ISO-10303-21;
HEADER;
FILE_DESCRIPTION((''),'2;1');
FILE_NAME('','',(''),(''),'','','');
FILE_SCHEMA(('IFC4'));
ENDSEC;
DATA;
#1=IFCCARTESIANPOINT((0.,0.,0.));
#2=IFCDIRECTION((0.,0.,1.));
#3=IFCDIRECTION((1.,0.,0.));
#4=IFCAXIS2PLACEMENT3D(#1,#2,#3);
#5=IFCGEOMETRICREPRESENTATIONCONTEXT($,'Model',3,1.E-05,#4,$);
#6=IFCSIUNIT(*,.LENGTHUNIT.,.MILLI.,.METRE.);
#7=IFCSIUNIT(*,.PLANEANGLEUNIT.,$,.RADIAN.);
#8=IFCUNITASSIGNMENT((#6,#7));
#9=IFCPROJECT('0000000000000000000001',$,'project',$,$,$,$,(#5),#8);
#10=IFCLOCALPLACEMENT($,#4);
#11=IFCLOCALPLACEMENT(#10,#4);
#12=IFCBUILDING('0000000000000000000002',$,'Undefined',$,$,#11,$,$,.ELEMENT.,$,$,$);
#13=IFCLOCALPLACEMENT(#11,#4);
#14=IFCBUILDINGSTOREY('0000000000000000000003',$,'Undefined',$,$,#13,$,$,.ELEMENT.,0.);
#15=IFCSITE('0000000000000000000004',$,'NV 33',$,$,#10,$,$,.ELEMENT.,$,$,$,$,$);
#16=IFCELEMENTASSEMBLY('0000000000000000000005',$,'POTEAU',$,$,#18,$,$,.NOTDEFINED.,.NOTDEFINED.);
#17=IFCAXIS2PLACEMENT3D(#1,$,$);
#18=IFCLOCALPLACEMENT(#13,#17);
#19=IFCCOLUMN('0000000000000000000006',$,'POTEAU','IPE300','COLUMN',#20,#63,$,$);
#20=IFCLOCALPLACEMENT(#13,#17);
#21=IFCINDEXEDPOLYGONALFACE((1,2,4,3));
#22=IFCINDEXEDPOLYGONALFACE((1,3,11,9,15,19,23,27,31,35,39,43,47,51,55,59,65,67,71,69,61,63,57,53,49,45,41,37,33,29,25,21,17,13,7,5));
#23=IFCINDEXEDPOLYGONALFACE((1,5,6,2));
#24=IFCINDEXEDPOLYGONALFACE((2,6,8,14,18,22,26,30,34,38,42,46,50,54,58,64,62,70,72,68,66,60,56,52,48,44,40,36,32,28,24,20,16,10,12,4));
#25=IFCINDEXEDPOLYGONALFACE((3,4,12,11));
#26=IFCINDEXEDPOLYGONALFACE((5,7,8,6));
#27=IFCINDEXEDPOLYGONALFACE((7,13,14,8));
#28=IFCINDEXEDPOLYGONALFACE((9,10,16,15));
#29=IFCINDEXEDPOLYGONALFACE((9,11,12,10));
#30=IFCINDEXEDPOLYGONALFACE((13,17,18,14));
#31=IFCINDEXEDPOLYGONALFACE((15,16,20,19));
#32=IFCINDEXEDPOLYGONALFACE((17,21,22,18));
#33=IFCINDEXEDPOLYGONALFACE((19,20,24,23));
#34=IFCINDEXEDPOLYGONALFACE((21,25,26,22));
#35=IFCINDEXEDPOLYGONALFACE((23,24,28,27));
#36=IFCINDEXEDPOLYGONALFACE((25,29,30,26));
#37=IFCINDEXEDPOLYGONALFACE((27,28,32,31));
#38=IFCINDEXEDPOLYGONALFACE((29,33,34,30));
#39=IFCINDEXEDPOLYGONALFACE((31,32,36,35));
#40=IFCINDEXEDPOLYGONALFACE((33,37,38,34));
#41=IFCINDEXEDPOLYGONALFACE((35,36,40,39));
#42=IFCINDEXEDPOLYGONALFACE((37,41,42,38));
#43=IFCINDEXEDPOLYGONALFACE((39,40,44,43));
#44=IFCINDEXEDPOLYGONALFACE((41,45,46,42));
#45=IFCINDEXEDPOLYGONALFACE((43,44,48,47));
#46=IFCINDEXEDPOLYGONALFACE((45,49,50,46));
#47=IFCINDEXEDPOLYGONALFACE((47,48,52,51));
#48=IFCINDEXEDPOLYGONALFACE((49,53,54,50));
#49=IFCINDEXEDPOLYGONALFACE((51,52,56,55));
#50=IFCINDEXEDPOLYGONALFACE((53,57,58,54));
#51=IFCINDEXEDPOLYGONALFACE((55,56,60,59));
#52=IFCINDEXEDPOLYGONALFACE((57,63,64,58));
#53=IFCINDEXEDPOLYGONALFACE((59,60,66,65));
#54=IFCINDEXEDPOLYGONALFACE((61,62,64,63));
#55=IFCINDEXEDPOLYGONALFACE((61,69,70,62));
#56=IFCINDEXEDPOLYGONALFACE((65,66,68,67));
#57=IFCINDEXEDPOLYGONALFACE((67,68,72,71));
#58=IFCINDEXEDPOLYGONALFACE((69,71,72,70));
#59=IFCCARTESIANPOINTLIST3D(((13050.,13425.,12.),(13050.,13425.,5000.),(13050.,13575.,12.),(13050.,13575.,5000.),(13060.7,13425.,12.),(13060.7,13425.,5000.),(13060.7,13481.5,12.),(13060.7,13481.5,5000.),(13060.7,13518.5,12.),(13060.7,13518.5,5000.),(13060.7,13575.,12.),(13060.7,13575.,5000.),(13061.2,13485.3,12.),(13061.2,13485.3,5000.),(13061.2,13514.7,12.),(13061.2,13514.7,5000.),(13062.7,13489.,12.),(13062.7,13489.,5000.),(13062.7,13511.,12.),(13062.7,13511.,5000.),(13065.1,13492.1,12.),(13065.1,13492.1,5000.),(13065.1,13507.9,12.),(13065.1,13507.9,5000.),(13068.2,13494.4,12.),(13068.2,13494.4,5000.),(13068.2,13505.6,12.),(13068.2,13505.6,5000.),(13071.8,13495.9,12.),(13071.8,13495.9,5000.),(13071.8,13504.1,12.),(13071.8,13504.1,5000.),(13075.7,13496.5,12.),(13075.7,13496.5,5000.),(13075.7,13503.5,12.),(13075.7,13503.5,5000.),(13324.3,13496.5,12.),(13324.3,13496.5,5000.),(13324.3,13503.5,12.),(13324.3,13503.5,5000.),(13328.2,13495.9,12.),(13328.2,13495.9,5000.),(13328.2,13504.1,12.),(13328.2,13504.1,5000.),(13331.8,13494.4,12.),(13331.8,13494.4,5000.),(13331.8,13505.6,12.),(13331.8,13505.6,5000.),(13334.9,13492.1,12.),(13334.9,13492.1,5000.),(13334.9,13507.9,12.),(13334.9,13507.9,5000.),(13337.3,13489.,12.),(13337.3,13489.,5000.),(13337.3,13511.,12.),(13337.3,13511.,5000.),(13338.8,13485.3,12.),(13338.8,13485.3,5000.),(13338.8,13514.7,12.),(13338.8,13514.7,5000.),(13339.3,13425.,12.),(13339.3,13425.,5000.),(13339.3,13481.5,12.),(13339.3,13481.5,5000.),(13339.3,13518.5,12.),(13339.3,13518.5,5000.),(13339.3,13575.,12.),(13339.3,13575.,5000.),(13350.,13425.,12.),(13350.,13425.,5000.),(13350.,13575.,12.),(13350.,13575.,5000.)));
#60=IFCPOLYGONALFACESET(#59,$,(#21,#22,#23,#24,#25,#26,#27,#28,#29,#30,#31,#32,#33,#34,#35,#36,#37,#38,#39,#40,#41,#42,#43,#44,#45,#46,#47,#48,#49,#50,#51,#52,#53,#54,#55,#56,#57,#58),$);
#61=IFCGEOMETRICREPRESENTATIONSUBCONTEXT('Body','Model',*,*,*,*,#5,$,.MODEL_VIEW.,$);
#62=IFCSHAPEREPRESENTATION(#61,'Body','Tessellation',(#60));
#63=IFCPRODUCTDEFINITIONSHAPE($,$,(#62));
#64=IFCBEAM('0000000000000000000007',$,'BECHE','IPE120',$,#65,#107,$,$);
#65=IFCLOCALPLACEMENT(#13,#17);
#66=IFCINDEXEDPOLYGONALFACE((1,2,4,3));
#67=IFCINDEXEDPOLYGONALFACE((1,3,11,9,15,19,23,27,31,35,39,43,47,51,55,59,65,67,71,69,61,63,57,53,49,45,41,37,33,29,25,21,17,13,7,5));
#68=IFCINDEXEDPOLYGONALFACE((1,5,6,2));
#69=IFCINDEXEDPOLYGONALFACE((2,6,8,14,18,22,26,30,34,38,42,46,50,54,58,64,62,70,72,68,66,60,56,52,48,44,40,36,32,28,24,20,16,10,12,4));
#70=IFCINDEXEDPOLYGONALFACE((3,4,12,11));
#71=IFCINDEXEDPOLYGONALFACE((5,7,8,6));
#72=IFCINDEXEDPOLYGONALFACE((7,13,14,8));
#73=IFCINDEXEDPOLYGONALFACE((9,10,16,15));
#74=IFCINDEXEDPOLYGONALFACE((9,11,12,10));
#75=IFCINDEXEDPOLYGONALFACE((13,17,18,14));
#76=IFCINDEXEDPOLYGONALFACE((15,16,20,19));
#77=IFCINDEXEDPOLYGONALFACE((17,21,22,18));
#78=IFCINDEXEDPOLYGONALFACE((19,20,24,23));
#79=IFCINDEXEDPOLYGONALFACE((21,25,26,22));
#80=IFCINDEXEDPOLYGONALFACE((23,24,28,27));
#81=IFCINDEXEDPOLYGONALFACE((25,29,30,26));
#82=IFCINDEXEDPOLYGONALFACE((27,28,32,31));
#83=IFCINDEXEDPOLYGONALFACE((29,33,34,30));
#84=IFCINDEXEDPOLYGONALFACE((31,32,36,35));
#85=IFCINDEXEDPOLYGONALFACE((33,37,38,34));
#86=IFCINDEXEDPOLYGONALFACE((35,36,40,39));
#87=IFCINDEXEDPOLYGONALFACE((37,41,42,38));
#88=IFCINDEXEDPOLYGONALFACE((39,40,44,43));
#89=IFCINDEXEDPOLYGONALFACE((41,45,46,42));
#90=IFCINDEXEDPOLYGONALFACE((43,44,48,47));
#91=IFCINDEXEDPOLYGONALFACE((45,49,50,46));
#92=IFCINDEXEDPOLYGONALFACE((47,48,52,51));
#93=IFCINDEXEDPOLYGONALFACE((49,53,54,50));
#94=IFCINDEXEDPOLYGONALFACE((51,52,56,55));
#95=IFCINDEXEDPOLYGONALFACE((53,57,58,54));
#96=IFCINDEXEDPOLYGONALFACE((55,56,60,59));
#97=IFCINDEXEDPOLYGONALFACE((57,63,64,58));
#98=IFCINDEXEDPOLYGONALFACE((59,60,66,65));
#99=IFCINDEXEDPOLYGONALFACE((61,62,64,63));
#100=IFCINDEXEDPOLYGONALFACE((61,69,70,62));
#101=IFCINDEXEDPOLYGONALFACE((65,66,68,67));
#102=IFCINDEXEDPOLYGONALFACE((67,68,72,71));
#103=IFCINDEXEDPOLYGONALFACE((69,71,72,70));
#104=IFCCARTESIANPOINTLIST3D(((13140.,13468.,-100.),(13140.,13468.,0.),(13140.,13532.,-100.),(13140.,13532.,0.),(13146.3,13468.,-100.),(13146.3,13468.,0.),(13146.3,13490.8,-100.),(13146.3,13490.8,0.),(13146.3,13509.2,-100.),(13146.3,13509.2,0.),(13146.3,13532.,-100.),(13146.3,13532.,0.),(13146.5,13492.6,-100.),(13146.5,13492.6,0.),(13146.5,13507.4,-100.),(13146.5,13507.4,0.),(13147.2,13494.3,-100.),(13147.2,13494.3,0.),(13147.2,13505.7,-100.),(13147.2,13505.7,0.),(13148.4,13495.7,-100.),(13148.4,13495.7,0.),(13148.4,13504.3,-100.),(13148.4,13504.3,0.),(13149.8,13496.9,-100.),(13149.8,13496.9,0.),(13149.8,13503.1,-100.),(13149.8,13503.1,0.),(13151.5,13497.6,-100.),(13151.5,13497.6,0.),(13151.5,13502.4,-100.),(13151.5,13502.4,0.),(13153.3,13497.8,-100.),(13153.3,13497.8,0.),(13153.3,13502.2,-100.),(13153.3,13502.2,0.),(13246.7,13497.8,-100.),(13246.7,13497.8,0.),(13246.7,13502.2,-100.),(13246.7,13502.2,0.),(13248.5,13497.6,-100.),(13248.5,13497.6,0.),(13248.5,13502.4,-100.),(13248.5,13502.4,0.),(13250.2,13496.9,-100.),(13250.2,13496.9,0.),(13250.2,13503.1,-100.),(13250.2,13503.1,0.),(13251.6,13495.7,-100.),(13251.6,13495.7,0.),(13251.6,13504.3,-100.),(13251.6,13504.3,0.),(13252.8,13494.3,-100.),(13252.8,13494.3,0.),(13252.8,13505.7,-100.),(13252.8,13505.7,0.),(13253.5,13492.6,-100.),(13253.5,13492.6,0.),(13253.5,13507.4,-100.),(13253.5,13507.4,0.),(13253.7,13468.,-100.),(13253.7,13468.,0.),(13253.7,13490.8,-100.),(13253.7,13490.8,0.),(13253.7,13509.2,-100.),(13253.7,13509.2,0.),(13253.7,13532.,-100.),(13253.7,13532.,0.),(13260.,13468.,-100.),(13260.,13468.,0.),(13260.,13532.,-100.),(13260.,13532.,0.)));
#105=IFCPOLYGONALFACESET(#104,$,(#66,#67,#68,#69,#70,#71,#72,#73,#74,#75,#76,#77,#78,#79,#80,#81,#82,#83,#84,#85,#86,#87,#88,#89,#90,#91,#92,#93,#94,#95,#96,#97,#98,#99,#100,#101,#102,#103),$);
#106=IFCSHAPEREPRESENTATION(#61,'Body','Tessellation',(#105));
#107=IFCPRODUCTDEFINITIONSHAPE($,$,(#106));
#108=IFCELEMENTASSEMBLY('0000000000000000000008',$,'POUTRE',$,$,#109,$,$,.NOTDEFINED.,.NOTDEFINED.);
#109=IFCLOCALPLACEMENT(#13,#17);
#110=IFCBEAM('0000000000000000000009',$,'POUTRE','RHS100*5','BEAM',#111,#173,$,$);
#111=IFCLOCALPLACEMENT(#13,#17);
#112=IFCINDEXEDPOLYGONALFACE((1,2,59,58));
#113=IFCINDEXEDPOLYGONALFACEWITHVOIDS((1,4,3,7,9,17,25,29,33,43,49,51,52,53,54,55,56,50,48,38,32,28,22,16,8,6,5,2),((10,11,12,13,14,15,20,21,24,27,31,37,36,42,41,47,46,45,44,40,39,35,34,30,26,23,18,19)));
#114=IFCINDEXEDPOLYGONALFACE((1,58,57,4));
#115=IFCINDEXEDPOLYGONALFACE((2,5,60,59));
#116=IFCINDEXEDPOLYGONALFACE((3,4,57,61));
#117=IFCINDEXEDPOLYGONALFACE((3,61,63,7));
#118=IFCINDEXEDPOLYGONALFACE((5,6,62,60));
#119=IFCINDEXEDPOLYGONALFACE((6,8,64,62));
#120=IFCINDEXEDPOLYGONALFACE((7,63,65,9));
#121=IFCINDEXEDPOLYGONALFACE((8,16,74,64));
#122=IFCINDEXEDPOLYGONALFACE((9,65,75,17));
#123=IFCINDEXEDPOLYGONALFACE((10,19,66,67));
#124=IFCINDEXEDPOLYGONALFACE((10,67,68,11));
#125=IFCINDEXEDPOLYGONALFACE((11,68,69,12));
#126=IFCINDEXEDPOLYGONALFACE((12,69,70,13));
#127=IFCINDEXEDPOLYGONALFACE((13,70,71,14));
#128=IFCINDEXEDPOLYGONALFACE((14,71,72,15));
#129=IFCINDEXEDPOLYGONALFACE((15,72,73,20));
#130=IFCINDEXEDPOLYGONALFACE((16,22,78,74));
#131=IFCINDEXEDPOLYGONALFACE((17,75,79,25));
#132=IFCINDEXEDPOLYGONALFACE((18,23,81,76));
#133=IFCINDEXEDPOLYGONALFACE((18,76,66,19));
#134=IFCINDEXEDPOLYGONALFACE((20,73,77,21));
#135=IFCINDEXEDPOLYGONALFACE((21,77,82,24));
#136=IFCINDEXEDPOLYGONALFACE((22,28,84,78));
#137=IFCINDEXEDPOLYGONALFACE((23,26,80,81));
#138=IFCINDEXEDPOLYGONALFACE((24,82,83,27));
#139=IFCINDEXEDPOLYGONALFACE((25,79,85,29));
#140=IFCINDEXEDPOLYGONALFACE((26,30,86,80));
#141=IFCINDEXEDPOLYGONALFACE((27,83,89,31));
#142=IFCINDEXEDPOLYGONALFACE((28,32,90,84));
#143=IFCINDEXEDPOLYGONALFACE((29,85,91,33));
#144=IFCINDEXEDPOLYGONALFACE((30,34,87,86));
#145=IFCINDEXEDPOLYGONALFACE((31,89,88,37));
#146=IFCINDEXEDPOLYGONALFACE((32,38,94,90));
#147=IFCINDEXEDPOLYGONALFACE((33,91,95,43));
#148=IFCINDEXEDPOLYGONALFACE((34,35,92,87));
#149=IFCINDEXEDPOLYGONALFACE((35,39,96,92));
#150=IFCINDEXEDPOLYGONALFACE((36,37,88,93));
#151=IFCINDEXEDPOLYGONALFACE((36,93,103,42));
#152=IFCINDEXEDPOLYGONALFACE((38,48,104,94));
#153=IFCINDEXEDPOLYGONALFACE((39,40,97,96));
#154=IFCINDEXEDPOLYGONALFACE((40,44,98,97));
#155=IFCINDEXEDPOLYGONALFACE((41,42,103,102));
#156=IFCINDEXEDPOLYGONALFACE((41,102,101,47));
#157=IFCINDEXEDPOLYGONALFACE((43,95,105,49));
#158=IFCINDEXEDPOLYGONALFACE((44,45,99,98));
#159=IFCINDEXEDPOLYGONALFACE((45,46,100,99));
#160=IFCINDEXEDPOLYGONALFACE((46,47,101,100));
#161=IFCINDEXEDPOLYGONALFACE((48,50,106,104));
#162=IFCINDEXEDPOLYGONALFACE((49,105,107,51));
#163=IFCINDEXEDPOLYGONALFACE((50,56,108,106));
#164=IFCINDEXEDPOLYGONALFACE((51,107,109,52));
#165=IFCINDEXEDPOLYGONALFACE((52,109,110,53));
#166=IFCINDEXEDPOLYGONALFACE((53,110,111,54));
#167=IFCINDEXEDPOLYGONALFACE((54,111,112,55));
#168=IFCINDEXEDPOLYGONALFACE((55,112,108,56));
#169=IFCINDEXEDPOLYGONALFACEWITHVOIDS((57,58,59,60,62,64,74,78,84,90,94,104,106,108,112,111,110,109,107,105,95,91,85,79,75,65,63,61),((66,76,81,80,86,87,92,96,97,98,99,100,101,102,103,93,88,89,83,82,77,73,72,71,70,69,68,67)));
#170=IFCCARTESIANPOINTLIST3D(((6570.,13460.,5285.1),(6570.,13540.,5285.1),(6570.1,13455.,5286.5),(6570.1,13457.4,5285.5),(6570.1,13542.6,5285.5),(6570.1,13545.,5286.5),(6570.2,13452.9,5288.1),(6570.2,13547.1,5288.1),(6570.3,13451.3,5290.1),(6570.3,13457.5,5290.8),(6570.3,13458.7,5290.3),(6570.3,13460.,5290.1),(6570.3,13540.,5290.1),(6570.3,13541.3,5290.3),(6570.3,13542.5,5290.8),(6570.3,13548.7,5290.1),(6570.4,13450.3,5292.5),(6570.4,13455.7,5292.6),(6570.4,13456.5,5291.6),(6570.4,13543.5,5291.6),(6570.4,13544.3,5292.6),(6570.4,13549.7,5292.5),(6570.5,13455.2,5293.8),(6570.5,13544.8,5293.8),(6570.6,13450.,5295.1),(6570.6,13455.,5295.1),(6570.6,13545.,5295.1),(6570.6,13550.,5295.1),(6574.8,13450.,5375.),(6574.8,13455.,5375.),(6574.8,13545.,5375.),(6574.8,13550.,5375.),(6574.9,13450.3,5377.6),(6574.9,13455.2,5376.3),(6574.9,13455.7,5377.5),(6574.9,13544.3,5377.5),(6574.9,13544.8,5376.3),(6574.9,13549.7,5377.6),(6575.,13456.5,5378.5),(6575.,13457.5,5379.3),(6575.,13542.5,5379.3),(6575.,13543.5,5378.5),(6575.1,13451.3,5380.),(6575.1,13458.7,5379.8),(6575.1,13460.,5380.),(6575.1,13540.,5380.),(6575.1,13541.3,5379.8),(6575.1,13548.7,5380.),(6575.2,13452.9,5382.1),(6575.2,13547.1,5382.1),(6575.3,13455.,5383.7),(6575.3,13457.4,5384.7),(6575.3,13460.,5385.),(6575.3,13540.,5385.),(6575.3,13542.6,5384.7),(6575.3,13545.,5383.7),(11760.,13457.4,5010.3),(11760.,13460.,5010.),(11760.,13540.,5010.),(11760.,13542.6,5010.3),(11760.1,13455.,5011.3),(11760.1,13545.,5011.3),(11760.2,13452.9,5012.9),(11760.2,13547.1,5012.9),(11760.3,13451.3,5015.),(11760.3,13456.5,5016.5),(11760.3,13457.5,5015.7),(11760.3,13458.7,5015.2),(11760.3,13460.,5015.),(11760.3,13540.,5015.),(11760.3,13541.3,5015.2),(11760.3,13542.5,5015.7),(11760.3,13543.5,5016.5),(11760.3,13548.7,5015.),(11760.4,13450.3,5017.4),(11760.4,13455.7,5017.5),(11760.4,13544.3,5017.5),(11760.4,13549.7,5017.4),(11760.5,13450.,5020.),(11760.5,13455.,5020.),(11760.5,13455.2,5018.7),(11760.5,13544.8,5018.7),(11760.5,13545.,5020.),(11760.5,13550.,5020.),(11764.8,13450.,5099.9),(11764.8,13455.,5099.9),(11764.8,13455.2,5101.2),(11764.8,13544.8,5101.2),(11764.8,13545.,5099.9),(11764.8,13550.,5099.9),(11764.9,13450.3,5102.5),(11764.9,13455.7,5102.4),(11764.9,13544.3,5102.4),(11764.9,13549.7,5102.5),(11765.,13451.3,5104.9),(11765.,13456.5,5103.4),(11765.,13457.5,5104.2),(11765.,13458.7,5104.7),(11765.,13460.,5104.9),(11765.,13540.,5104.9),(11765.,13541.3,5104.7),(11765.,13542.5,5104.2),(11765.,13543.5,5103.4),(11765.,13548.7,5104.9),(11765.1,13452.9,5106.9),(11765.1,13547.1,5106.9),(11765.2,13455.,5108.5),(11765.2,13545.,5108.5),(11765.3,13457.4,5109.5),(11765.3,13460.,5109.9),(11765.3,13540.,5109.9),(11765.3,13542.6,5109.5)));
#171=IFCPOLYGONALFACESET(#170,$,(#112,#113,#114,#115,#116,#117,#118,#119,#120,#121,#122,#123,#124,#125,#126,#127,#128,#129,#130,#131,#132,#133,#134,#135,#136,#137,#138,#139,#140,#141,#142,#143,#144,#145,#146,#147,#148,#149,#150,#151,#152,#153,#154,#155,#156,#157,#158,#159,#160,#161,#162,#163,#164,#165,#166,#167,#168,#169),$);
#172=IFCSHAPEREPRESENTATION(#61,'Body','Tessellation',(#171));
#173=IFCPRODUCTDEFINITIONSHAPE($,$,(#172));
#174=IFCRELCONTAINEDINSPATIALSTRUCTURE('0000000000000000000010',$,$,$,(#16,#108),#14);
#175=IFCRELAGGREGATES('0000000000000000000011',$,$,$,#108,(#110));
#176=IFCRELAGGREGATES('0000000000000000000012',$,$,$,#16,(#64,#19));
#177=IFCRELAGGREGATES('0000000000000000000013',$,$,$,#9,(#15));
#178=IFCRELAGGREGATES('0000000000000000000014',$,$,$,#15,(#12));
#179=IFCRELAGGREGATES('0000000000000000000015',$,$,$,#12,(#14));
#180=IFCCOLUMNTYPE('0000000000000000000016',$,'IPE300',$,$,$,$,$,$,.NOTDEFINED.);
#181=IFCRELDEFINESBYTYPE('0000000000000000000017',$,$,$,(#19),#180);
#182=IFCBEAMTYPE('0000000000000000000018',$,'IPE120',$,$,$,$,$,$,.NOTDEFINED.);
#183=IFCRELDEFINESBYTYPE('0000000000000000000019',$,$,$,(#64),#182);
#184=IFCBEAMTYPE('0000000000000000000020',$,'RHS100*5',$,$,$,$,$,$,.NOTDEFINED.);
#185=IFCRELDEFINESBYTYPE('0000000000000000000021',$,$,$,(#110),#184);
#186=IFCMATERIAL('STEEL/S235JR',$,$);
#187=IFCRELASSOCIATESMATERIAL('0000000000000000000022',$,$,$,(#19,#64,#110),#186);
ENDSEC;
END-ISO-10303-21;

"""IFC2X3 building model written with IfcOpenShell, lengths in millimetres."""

from ifc_helpers import new_model, si_unit, frame, origin_with_axes, origin_2d_with_axis, place, context, subcontext, project, spatial, hollow_rectangle, i_section, extrude, boolean, clip, halfspace, material, type_object, element, aggregate, save


model = new_model("IFC2X3")

# Units and contexts
model_context = context("Model", 3, precision=1e-05, world=origin_with_axes())
body_context = subcontext(model_context, "Body", "Model", "MODEL_VIEW")
ifc_project = project(units=[si_unit("LENGTHUNIT", "METRE", prefix="MILLI"), si_unit("PLANEANGLEUNIT", "RADIAN")], contexts=[model_context])

# Site, building, storey
site_placement = place(None, origin_with_axes())
site = spatial("IfcSite", under=ifc_project, at=site_placement, Name="NV 33", CompositionType="ELEMENT")
building_placement = place(site_placement, origin_with_axes())
building = spatial("IfcBuilding", under=site, at=building_placement, Name="Undefined", CompositionType="ELEMENT")
storey_placement = place(building_placement, origin_with_axes())
storey = spatial("IfcBuildingStorey", under=building, at=storey_placement, Name="Undefined", CompositionType="ELEMENT", Elevation=0.0)

# Element assembly, column, beam
assembly_1_placement = place(storey_placement, origin_with_axes())
assembly_1 = element("IfcElementAssembly", 1, at=assembly_1_placement, inside=storey, Name="POTEAU", AssemblyPlace="NOTDEFINED", PredefinedType="NOTDEFINED")
ifc_material_1 = material(Name="STEEL/S235JR")
column_type = type_object("IfcColumnType", Name="IPE300", PredefinedType="NOTDEFINED")
column_placement = place(assembly_1_placement, frame((13200.0, 13500.0, 0.0), z_axis=(0.0, 0.0, 1.0), x_axis=(-1.0, 0.0, 0.0)))
column = element("IfcColumn", 2, at=column_placement, type_object=column_type, material=ifc_material_1, Name="POTEAU", Description="IPE300", ObjectType="COLUMN", context=body_context, shape_type="Clipping", body=[
    clip(clip(extrude(i_section(OverallWidth=150.0, OverallDepth=300.0, WebThickness=7.1, FlangeThickness=10.7, FilletRadius=15.0, at=origin_2d_with_axis()), frame((0.0, 0.0, 5000.0), z_axis=(0.0, 0.0, -1.0), x_axis=(0.0, 1.0, 0.0)), (0.0, 0.0, 1.0), 5000.0), halfspace(frame((-150.0, 0.0, 5000.0), z_axis=(0.0, 0.0, -1.0), x_axis=(0.0, -1.0, 0.0)), True)), halfspace(frame((-150.0, 0.0, 12.0), z_axis=(0.0, 0.0, 1.0), x_axis=(0.0, 1.0, 0.0)), True)),
])
beam_type_1 = type_object("IfcBeamType", Name="IPE120", PredefinedType="NOTDEFINED")
beam_1_placement = place(assembly_1_placement, frame((13200.0, 13500.0, 0.0), z_axis=(-1.0, 0.0, 0.0), x_axis=(0.0, 0.0, -1.0)))
beam_1 = element("IfcBeam", 3, at=beam_1_placement, type_object=beam_type_1, material=ifc_material_1, Name="BECHE", Description="IPE120", context=body_context, shape_type="SweptSolid", body=[
    extrude(i_section(OverallWidth=64.0, OverallDepth=120.0, WebThickness=4.4, FlangeThickness=6.3, FilletRadius=7.0, at=origin_2d_with_axis()), frame((100.0, 0.0, 0.0), z_axis=(-1.0, 0.0, 0.0), x_axis=(0.0, -1.0, 0.0)), (0.0, 0.0, 1.0), 100.0),
])

# Element assembly, beam
beam_type_2 = type_object("IfcBeamType", Name="RHS100*5", PredefinedType="NOTDEFINED")
assembly_2_placement = place(storey_placement, origin_with_axes())
assembly_2 = element("IfcElementAssembly", 4, at=assembly_2_placement, inside=storey, Name="POUTRE", AssemblyPlace="NOTDEFINED", PredefinedType="NOTDEFINED")
beam_2_placement = place(assembly_2_placement, frame((11762.6, 13500.0, 5059.9), z_axis=(-0.052941, 0.0, -0.998598), x_axis=(-0.998598, 0.0, 0.052941)))
solid_1 = boolean("DIFFERENCE", boolean("DIFFERENCE", extrude(hollow_rectangle(XDim=100.0, YDim=100.0, WallThickness=5.0, InnerFilletRadius=5.0, OuterFilletRadius=10.0, at=origin_2d_with_axis()), frame((5142.7, 0.0, -2.9), z_axis=(0.994395, 0.0, 0.105733), x_axis=(0.0, 1.0, 0.0)), (0.0, 0.0, 1.0), 5197.2), extrude(hollow_rectangle(XDim=100.0, YDim=100.0, WallThickness=5.0, InnerFilletRadius=5.0, OuterFilletRadius=10.0, at=origin_2d_with_axis()), frame((10308.2, 0.0, 546.4), z_axis=(0.998598, 0.0, 0.052941), x_axis=(-0.052941, 0.0, 0.998598)), (0.0, 0.0, 1.0), 1600.0)), halfspace(frame((5172.5, 50.0, -50.0), z_axis=(-0.998598, 0.0, -0.052941), x_axis=(-0.052941, 0.0, 0.998598)), False))
beam_2 = element("IfcBeam", 5, at=beam_2_placement, type_object=beam_type_2, material=ifc_material_1, Name="POUTRE", Description="RHS100*5", ObjectType="BEAM", context=body_context, shape_type="CSG", body=[
    boolean("DIFFERENCE", boolean("DIFFERENCE", boolean("DIFFERENCE", extrude(hollow_rectangle(XDim=100.0, YDim=100.0, WallThickness=5.0, InnerFilletRadius=5.0, OuterFilletRadius=10.0, at=origin_2d_with_axis()), frame((5197.2, 0.0, 0.0), z_axis=(-1.0, 0.0, 0.0), x_axis=(0.0, -1.0, 0.0)), (0.0, 0.0, 1.0), 5197.2), solid_1), extrude(hollow_rectangle(XDim=100.0, YDim=100.0, WallThickness=5.0, InnerFilletRadius=5.0, OuterFilletRadius=10.0, at=origin_2d_with_axis()), frame((2.6, 0.0, 0.1), z_axis=(-0.998598, 0.0, -0.052941), x_axis=(0.052941, 0.0, -0.998598)), (0.0, 0.0, 1.0), 1600.0)), halfspace(frame((5172.5, 50.0, -50.0), z_axis=(0.998598, 0.0, 0.052941), x_axis=(0.0, -1.0, 0.0)), False)),
])
aggregate(assembly_2, [beam_2])

aggregate(assembly_1, [beam_1, column])

save(model, "model.ifc")
